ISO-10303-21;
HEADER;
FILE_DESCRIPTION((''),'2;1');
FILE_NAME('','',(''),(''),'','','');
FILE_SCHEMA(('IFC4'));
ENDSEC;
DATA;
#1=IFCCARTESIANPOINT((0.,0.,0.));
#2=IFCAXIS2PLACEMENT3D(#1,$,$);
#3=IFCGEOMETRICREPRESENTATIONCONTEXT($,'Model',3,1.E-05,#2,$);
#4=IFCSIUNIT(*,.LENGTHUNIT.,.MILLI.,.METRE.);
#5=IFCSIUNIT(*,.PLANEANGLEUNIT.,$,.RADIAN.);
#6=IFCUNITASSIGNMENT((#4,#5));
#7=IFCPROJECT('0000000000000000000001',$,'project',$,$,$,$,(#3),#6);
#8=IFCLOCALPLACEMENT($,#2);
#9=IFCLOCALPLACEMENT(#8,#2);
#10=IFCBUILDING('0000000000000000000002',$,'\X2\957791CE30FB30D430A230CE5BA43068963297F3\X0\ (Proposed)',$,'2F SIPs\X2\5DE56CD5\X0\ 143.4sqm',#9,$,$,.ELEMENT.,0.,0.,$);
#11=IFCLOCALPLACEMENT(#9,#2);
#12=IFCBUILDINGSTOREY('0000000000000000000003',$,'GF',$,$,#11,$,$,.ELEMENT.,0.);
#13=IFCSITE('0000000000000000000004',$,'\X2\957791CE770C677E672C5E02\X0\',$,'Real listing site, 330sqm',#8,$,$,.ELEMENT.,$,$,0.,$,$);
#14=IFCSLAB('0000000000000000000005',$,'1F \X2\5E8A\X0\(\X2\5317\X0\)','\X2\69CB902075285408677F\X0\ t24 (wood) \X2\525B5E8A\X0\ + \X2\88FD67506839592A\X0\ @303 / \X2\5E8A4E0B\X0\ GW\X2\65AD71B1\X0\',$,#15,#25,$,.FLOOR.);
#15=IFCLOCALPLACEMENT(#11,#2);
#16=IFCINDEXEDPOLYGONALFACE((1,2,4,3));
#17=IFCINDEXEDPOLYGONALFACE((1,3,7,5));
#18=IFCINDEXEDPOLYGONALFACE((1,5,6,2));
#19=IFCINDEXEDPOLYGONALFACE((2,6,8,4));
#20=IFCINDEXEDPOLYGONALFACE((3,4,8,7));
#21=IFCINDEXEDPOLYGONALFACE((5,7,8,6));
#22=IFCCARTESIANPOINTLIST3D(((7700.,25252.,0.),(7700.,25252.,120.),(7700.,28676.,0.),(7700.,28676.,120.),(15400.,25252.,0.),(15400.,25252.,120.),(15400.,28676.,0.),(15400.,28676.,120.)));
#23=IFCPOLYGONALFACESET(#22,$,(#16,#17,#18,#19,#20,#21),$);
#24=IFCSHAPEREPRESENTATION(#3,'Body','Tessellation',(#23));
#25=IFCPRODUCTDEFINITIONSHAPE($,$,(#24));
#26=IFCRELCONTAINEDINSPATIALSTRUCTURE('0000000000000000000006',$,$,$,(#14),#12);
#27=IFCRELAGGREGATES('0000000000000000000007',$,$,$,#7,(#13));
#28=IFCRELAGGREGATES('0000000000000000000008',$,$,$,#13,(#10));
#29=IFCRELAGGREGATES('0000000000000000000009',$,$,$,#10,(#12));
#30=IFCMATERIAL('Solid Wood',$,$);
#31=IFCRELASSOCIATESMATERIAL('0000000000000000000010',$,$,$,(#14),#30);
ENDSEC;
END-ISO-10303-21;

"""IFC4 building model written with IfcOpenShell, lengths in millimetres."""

from ifc_helpers import new_model, si_unit, frame, frame_2d, origin, place, context, project, spatial, rectangle, extrude, material, element, save


model = new_model("IFC4")

# Units and contexts
model_context = context("Model", 3, precision=1e-05, world=origin())
ifc_project = project(units=[si_unit("LENGTHUNIT", "METRE", prefix="MILLI"), si_unit("PLANEANGLEUNIT", "RADIAN")], contexts=[model_context])

# Site, building, storey
site_placement = place(None, origin())
site = spatial("IfcSite", under=ifc_project, at=site_placement, Name="長野県松本市", ObjectType="Real listing site, 330sqm", CompositionType="ELEMENT", RefElevation=0.0)
building_placement = place(site_placement, origin())
building = spatial("IfcBuilding", under=site, at=building_placement, Name="長野・ピアノ室と防音 (Proposed)", ObjectType="2F SIPs工法 143.4sqm", CompositionType="ELEMENT", ElevationOfRefHeight=0.0, ElevationOfTerrain=0.0)
storey_placement = place(building_placement, origin())
storey = spatial("IfcBuildingStorey", under=building, at=storey_placement, Name="GF", CompositionType="ELEMENT", Elevation=0.0)

# Shared definitions
ifc_material_1 = material(Name="Solid Wood")

# Slab
slab_1_placement = place(storey_placement, frame((3850.0, 12626.0, 0.0)))
element("IfcSlab", 1, at=slab_1_placement, inside=storey, material=ifc_material_1, Name="1F 床(北)", Description="構造用合板 t24 (wood) 剛床 + 製材根太 @303 / 床下 GW断熱", PredefinedType="FLOOR", context=model_context, shape_type="SweptSolid", body=[
    extrude(rectangle(XDim=7700.0, YDim=3424.0, at=frame_2d((3850.0, 1712.0))), frame((3850.0, 12626.0, 0.0)), (0.0, 0.0, 1.0), 120.0),
])

save(model, "model.ifc")
